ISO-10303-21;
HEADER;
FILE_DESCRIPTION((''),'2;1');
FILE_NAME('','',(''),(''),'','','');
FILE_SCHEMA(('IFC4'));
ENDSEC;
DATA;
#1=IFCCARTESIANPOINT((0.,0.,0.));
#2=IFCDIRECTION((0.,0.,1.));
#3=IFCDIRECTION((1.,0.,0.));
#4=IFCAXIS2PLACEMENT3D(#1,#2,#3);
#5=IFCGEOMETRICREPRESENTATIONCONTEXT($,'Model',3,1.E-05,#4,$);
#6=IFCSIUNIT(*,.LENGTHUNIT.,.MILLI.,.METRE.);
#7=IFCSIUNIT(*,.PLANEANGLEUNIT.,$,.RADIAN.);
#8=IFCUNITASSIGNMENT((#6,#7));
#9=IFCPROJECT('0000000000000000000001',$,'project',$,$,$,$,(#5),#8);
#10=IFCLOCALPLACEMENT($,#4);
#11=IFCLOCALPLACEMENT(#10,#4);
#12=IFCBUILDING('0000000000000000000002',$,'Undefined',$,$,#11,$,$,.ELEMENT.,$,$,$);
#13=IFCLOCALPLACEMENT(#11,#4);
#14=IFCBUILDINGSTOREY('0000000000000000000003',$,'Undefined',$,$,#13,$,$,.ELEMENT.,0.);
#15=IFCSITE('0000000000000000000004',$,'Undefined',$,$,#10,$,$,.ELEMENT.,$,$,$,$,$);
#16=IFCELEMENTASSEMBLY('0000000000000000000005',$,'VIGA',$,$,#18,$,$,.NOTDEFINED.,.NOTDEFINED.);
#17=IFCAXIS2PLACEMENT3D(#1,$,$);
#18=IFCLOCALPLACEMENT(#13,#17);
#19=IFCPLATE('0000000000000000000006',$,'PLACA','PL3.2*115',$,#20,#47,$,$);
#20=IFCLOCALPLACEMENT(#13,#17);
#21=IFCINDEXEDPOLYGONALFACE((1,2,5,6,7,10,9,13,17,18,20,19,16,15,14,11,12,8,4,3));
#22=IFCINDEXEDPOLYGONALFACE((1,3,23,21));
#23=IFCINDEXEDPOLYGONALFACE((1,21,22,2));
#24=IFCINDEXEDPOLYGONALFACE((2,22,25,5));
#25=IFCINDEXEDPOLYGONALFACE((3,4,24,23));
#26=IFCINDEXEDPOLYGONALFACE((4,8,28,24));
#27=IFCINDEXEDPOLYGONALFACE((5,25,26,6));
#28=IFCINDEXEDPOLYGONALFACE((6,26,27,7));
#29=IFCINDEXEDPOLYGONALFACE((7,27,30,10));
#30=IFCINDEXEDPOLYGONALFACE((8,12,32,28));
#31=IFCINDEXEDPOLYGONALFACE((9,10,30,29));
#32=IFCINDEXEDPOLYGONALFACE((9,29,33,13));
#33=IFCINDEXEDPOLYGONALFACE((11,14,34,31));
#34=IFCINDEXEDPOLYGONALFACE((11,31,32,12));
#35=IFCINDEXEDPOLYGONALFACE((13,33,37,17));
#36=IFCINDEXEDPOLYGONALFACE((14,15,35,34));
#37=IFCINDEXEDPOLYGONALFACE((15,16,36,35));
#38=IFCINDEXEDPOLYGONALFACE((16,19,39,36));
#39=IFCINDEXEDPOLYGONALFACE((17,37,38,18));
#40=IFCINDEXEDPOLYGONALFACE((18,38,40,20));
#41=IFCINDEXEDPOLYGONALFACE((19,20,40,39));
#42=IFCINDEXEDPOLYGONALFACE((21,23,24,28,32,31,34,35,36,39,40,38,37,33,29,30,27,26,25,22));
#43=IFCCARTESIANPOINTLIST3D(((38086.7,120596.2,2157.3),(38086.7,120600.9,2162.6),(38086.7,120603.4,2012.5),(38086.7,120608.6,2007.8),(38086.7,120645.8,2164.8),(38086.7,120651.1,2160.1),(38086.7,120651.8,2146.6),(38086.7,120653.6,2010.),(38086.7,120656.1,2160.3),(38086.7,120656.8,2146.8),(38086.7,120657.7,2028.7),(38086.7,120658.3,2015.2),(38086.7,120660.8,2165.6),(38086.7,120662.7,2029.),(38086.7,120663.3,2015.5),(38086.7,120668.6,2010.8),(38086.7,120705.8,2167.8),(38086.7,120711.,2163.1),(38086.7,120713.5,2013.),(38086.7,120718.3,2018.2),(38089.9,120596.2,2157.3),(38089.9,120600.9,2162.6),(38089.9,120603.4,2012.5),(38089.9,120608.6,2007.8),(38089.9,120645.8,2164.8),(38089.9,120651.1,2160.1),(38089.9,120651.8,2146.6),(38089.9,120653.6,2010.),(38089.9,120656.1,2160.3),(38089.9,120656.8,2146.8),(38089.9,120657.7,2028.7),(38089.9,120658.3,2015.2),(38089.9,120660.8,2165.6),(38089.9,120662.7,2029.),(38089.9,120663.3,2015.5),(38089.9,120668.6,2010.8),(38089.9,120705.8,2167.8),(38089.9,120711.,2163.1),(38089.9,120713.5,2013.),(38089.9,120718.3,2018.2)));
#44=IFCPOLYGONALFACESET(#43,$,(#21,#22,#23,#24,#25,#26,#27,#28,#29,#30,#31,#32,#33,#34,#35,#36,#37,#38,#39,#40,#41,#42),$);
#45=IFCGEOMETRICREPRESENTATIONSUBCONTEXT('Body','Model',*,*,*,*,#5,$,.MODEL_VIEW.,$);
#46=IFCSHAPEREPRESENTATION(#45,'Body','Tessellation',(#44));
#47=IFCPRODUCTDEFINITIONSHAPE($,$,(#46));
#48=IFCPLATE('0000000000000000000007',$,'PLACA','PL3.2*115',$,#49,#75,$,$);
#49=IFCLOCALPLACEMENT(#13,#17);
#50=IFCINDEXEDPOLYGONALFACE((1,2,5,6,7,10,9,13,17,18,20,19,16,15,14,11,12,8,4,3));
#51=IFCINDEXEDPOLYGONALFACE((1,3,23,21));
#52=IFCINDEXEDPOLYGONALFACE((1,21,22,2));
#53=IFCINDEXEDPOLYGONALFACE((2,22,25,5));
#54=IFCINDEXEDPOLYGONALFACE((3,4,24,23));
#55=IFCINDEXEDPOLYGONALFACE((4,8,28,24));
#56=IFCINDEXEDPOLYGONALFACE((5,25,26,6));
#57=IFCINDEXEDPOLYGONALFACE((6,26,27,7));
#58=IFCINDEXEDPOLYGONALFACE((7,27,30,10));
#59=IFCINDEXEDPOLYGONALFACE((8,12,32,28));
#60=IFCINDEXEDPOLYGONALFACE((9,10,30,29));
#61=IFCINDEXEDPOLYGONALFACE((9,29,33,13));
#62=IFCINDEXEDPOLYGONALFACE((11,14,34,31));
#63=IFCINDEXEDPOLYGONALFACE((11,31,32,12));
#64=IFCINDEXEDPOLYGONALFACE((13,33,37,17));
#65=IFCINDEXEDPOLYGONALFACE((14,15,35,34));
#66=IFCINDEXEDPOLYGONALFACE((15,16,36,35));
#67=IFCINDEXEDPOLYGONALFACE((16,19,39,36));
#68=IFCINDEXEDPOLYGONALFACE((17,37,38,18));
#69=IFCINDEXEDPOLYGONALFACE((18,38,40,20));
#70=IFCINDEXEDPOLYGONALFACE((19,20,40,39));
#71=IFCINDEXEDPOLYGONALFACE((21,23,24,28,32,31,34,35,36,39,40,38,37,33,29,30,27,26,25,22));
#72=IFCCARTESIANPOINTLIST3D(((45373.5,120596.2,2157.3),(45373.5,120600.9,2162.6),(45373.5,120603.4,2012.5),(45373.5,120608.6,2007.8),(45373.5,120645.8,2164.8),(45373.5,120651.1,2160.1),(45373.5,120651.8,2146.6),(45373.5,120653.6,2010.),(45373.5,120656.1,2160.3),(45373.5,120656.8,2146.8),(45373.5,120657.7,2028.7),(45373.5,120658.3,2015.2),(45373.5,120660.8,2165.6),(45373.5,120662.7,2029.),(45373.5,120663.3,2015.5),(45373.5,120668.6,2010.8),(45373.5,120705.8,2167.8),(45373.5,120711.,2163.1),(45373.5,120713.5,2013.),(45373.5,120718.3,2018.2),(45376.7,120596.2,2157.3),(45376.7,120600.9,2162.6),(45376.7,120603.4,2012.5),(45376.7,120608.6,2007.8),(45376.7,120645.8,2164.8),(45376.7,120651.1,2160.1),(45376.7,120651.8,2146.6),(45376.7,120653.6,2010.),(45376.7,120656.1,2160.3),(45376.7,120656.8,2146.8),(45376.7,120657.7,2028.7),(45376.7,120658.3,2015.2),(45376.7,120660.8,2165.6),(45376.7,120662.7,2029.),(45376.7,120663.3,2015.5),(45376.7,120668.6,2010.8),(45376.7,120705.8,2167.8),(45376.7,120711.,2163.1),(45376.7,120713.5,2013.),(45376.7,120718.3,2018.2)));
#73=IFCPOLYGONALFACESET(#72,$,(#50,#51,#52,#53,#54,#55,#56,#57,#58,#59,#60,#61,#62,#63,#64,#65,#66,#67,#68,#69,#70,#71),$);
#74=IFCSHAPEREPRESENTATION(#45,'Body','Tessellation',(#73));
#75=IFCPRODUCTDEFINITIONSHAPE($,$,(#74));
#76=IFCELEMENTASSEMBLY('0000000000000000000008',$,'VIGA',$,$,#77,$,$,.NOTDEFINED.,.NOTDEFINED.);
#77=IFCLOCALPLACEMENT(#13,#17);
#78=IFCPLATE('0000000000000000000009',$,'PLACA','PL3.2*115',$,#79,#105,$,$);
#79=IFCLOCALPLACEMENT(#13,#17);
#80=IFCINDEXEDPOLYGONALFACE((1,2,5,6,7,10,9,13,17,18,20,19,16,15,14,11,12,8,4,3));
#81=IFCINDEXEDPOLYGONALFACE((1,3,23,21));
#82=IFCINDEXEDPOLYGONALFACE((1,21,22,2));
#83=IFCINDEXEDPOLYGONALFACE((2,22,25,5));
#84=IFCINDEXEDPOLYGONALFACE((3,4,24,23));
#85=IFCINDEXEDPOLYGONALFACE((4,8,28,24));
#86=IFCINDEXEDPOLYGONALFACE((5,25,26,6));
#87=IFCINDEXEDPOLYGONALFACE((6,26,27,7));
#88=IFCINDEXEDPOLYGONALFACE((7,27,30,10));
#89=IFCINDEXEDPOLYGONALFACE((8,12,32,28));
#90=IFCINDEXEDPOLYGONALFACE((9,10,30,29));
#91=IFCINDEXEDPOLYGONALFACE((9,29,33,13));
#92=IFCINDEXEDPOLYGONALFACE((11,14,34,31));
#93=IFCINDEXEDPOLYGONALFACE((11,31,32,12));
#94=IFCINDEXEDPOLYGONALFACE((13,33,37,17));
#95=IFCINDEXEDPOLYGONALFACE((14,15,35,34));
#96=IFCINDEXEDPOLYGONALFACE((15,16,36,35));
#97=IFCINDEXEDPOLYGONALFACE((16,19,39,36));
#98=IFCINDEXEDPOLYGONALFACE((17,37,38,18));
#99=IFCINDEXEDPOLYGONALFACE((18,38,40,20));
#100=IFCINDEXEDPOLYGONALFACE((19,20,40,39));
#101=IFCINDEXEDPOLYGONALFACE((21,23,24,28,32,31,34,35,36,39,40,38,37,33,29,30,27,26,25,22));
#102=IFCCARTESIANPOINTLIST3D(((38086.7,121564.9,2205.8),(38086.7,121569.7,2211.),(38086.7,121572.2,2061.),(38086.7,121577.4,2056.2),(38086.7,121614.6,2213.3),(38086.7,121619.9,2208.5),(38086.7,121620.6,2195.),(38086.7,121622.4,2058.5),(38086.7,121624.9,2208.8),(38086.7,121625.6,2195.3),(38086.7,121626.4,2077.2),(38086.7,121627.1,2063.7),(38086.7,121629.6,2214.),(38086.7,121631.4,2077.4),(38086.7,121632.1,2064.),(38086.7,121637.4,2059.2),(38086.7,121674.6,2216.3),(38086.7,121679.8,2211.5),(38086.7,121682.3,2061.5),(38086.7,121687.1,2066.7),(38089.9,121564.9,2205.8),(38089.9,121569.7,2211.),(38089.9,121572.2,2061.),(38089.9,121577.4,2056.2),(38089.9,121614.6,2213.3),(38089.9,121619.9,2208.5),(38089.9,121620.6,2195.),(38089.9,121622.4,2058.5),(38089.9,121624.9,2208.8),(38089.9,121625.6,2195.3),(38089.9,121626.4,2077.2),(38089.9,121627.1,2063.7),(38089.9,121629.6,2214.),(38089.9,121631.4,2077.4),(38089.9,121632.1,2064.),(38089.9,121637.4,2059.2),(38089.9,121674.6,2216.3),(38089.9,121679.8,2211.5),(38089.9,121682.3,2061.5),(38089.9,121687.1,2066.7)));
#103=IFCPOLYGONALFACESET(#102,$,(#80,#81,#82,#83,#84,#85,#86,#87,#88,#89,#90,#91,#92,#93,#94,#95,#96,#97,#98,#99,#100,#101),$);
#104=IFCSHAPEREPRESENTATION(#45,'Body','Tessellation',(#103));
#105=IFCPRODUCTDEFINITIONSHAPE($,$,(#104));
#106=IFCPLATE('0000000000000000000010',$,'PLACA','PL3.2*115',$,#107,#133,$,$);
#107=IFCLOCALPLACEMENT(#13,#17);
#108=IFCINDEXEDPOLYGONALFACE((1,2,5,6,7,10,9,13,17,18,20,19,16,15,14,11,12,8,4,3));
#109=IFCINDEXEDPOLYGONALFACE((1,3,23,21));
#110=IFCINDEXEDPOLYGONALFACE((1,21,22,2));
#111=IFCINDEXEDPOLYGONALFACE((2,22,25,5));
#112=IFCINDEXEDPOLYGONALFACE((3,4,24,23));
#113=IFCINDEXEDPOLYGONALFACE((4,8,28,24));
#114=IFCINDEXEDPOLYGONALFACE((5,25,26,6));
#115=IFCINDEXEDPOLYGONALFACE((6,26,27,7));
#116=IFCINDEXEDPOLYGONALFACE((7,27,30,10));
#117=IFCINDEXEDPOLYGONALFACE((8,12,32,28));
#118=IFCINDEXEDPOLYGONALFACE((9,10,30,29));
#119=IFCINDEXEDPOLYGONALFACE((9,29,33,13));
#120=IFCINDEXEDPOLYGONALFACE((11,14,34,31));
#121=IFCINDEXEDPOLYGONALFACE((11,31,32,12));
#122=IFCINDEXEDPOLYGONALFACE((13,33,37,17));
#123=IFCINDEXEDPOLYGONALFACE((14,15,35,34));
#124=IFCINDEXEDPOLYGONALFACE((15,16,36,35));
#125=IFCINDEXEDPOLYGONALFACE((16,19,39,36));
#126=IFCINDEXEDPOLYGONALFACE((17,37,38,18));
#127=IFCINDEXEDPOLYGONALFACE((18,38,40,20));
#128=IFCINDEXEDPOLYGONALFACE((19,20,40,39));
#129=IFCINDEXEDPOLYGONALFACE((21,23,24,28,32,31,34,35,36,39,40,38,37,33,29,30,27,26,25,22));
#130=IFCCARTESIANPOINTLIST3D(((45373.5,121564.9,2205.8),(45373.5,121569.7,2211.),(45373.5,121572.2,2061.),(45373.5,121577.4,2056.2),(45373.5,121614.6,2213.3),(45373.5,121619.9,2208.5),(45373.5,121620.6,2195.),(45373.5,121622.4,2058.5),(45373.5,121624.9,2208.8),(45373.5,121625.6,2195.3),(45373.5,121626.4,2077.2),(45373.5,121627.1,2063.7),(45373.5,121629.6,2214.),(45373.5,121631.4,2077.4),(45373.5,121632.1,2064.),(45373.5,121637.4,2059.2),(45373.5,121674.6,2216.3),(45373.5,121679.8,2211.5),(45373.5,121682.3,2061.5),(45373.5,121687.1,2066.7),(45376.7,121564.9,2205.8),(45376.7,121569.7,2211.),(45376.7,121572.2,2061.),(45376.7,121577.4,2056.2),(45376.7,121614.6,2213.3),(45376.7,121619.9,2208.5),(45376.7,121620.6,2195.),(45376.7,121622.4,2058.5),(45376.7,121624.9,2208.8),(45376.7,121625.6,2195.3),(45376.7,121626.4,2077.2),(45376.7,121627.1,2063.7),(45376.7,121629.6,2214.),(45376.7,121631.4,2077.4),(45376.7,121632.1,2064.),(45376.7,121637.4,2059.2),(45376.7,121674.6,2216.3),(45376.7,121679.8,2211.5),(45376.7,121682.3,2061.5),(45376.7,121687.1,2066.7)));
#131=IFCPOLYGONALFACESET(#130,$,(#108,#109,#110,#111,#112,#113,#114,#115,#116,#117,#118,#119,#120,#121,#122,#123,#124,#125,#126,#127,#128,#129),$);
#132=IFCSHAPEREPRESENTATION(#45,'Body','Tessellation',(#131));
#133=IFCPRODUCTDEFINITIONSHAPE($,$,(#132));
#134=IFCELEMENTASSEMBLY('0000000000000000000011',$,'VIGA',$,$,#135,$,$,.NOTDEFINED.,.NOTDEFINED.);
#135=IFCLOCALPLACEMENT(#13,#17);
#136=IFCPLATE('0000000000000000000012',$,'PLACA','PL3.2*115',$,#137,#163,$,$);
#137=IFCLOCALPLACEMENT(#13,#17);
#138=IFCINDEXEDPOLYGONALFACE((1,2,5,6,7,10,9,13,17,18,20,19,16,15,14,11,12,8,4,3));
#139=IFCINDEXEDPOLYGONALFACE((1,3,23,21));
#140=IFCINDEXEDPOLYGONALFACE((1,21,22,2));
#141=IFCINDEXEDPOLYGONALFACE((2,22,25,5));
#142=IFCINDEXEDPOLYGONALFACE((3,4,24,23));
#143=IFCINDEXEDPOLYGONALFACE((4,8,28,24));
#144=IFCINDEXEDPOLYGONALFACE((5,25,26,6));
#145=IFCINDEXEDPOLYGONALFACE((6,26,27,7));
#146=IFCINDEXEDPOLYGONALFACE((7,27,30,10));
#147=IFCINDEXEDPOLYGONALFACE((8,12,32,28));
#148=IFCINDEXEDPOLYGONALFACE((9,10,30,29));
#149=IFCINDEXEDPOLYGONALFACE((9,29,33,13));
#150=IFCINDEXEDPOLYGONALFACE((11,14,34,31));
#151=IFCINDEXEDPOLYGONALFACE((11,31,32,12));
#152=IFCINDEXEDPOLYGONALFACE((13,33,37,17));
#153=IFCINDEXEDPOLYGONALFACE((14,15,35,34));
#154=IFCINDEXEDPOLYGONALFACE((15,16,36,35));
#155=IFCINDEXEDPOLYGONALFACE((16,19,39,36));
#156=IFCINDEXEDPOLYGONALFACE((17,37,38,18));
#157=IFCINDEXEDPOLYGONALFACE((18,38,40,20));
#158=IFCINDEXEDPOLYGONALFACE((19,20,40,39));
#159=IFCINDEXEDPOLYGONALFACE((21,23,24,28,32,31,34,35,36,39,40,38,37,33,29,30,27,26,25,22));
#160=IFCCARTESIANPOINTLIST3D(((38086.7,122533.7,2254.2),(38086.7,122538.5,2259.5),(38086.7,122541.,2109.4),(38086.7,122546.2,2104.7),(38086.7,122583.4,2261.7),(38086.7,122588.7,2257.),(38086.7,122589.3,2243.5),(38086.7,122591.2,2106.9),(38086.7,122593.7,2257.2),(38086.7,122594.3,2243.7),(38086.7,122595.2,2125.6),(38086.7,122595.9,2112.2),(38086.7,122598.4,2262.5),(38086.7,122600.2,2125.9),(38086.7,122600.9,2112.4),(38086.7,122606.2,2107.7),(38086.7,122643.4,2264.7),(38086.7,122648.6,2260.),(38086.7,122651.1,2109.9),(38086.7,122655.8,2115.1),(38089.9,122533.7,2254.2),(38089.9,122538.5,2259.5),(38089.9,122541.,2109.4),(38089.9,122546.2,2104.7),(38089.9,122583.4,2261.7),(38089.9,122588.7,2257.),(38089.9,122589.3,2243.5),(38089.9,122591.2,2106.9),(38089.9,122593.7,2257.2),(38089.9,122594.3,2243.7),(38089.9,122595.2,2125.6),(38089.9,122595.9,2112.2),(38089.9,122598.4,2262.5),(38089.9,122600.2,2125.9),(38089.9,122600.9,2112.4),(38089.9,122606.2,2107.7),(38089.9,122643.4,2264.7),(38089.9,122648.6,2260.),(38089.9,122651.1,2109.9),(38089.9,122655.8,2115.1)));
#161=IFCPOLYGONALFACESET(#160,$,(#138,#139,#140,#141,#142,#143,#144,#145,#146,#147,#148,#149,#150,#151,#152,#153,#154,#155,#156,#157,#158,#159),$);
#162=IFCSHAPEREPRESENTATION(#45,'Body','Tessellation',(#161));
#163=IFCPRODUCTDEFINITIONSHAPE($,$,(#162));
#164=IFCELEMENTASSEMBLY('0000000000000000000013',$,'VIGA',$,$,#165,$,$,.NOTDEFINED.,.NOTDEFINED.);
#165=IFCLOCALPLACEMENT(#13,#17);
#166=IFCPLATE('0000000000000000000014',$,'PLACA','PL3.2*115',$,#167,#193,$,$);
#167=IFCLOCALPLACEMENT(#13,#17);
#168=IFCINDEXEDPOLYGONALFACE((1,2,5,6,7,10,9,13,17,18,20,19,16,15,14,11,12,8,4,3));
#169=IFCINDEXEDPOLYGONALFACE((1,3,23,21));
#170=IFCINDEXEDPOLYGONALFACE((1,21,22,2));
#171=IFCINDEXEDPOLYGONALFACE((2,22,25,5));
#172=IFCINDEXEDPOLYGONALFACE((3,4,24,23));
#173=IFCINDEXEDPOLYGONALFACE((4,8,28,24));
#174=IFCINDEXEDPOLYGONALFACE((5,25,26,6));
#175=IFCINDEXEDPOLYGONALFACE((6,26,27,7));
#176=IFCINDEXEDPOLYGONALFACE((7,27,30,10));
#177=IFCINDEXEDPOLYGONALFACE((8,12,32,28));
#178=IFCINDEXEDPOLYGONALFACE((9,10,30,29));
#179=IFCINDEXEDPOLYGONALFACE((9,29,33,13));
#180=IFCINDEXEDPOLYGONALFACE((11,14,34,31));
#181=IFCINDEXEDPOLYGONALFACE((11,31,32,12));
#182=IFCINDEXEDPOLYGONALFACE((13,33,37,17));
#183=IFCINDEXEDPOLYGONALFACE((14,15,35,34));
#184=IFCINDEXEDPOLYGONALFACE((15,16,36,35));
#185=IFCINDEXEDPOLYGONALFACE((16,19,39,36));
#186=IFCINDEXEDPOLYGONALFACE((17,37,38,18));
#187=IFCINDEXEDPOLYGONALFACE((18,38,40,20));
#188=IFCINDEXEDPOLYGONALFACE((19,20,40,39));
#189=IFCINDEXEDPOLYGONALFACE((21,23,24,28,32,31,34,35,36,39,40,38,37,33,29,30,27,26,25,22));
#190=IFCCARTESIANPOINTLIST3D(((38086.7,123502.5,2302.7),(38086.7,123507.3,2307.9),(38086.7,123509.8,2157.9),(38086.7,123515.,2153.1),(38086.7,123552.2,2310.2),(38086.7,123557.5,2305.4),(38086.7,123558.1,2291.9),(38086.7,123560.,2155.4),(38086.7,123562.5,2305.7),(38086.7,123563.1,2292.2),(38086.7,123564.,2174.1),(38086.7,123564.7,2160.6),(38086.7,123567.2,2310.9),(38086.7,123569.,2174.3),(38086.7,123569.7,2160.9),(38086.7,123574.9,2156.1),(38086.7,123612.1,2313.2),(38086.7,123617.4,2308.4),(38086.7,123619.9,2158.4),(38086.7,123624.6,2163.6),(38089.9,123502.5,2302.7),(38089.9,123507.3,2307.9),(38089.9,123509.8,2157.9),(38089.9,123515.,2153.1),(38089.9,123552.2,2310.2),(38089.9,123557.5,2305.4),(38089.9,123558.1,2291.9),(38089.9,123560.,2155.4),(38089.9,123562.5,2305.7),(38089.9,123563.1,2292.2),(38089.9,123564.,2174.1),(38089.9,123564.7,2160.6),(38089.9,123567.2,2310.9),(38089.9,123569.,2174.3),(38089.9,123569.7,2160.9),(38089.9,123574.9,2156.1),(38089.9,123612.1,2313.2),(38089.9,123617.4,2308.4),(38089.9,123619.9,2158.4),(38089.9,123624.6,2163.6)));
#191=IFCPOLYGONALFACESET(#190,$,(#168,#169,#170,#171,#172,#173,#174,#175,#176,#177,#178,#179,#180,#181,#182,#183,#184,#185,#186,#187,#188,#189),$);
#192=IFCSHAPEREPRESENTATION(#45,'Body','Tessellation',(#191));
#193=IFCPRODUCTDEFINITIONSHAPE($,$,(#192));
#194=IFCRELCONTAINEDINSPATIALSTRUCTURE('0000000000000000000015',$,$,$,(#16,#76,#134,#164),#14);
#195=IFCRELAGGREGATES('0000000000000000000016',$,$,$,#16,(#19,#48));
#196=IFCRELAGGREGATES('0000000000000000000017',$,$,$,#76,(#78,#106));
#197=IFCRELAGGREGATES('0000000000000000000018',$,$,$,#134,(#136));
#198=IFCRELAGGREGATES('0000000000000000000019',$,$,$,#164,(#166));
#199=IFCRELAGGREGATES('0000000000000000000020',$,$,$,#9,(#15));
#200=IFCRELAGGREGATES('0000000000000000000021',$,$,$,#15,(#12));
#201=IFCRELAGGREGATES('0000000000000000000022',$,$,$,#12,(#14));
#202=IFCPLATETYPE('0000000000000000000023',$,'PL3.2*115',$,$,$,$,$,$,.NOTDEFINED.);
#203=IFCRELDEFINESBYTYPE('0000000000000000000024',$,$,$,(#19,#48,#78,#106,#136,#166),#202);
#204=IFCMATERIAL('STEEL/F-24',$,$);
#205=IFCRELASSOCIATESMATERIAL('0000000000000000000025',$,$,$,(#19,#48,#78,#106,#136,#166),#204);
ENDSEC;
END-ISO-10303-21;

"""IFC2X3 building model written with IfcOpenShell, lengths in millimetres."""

from ifc_helpers import new_model, si_unit, frame, origin_with_axes, place, context, subcontext, project, spatial, polyline, outline, extrude, material, type_object, element, aggregate, save


model = new_model("IFC2X3")

# Units and contexts
model_context = context("Model", 3, precision=1e-05, world=origin_with_axes())
body_context = subcontext(model_context, "Body", "Model", "MODEL_VIEW")
ifc_project = project(units=[si_unit("LENGTHUNIT", "METRE", prefix="MILLI"), si_unit("PLANEANGLEUNIT", "RADIAN")], contexts=[model_context])

# Site, building, storey
site_placement = place(None, origin_with_axes())
site = spatial("IfcSite", under=ifc_project, at=site_placement, Name="Undefined", CompositionType="ELEMENT")
building_placement = place(site_placement, origin_with_axes())
building = spatial("IfcBuilding", under=site, at=building_placement, Name="Undefined", CompositionType="ELEMENT")
storey_placement = place(building_placement, origin_with_axes())
storey = spatial("IfcBuildingStorey", under=building, at=storey_placement, Name="Undefined", CompositionType="ELEMENT", Elevation=0.0)

# Shared definitions
ifc_material_1 = material(Name="STEEL/F-24")

# Element assemblies, plates
assembly_1_placement = place(storey_placement, origin_with_axes())
assembly_1 = element("IfcElementAssembly", 1, at=assembly_1_placement, inside=storey, Name="VIGA", AssemblyPlace="NOTDEFINED", PredefinedType="NOTDEFINED")
plate_type_1 = type_object("IfcPlateType", Name="PL3.2*115", PredefinedType="NOTDEFINED")
plate_1_placement = place(assembly_1_placement, frame((38088.3, 120595.9, 2162.3), z_axis=(-1.0, 0.0, 0.0), x_axis=(0.0, 0.998752, 0.04995)))
plate_1 = element("IfcPlate", 2, at=plate_1_placement, type_object=plate_type_1, material=ifc_material_1, Name="PLACA", Description="PL3.2*115", context=body_context, shape_type="SweptSolid", body=[
    extrude(outline(polyline([(0.0, 5.0), (5.0, 0.0), (50.0, 0.0), (55.0, 5.0), (55.0, 18.5), (60.0, 18.5), (60.0, 5.0), (65.0, 0.0), (110.0, 0.0), (115.0, 5.0), (115.0, 150.0), (110.0, 155.0), (65.0, 155.0), (60.0, 150.0), (60.0, 136.5), (55.0, 136.5), (55.0, 150.0), (50.0, 155.0), (5.0, 155.0), (0.0, 150.0), (0.0, 5.0)])), frame((0.0, 0.0, -1.6), z_axis=(0.0, 0.0, 1.0), x_axis=(1.0, 0.0, 0.0)), (0.0, 0.0, 1.0), 3.2),
])
plate_2_placement = place(assembly_1_placement, frame((45375.1, 120595.9, 2162.3), z_axis=(-1.0, 0.0, 0.0), x_axis=(0.0, 0.998752, 0.04995)))
plate_2 = element("IfcPlate", 3, at=plate_2_placement, type_object=plate_type_1, material=ifc_material_1, Name="PLACA", Description="PL3.2*115", context=body_context, shape_type="SweptSolid", body=[
    extrude(outline(polyline([(0.0, 5.0), (5.0, 0.0), (50.0, 0.0), (55.0, 5.0), (55.0, 18.5), (60.0, 18.5), (60.0, 5.0), (65.0, 0.0), (110.0, 0.0), (115.0, 5.0), (115.0, 150.0), (110.0, 155.0), (65.0, 155.0), (60.0, 150.0), (60.0, 136.5), (55.0, 136.5), (55.0, 150.0), (50.0, 155.0), (5.0, 155.0), (0.0, 150.0), (0.0, 5.0)])), frame((0.0, 0.0, -1.6), z_axis=(0.0, 0.0, 1.0), x_axis=(1.0, 0.0, 0.0)), (0.0, 0.0, 1.0), 3.2),
])
assembly_2_placement = place(storey_placement, origin_with_axes())
assembly_2 = element("IfcElementAssembly", 4, at=assembly_2_placement, inside=storey, Name="VIGA", AssemblyPlace="NOTDEFINED", PredefinedType="NOTDEFINED")
plate_3_placement = place(assembly_2_placement, frame((38088.3, 121564.7, 2210.8), z_axis=(-1.0, 0.0, 0.0), x_axis=(0.0, 0.998752, 0.04995)))
plate_3 = element("IfcPlate", 5, at=plate_3_placement, type_object=plate_type_1, material=ifc_material_1, Name="PLACA", Description="PL3.2*115", context=body_context, shape_type="SweptSolid", body=[
    extrude(outline(polyline([(0.0, 5.0), (5.0, 0.0), (50.0, 0.0), (55.0, 5.0), (55.0, 18.5), (60.0, 18.5), (60.0, 5.0), (65.0, 0.0), (110.0, 0.0), (115.0, 5.0), (115.0, 150.0), (110.0, 155.0), (65.0, 155.0), (60.0, 150.0), (60.0, 136.5), (55.0, 136.5), (55.0, 150.0), (50.0, 155.0), (5.0, 155.0), (0.0, 150.0), (0.0, 5.0)])), frame((0.0, 0.0, -1.6), z_axis=(0.0, 0.0, 1.0), x_axis=(1.0, 0.0, 0.0)), (0.0, 0.0, 1.0), 3.2),
])
plate_4_placement = place(assembly_2_placement, frame((45375.1, 121564.7, 2210.8), z_axis=(-1.0, 0.0, 0.0), x_axis=(0.0, 0.998752, 0.04995)))
plate_4 = element("IfcPlate", 6, at=plate_4_placement, type_object=plate_type_1, material=ifc_material_1, Name="PLACA", Description="PL3.2*115", context=body_context, shape_type="SweptSolid", body=[
    extrude(outline(polyline([(0.0, 5.0), (5.0, 0.0), (50.0, 0.0), (55.0, 5.0), (55.0, 18.5), (60.0, 18.5), (60.0, 5.0), (65.0, 0.0), (110.0, 0.0), (115.0, 5.0), (115.0, 150.0), (110.0, 155.0), (65.0, 155.0), (60.0, 150.0), (60.0, 136.5), (55.0, 136.5), (55.0, 150.0), (50.0, 155.0), (5.0, 155.0), (0.0, 150.0), (0.0, 5.0)])), frame((0.0, 0.0, -1.6), z_axis=(0.0, 0.0, 1.0), x_axis=(1.0, 0.0, 0.0)), (0.0, 0.0, 1.0), 3.2),
])

# Element assemblies, plates
assembly_3_placement = place(storey_placement, origin_with_axes())
assembly_3 = element("IfcElementAssembly", 7, at=assembly_3_placement, inside=storey, Name="VIGA", AssemblyPlace="NOTDEFINED", PredefinedType="NOTDEFINED")
plate_5_placement = place(assembly_3_placement, frame((38088.3, 122533.5, 2259.2), z_axis=(-1.0, 0.0, 0.0), x_axis=(0.0, 0.998752, 0.04995)))
plate_5 = element("IfcPlate", 8, at=plate_5_placement, type_object=plate_type_1, material=ifc_material_1, Name="PLACA", Description="PL3.2*115", context=body_context, shape_type="SweptSolid", body=[
    extrude(outline(polyline([(0.0, 5.0), (5.0, 0.0), (50.0, 0.0), (55.0, 5.0), (55.0, 18.5), (60.0, 18.5), (60.0, 5.0), (65.0, 0.0), (110.0, 0.0), (115.0, 5.0), (115.0, 150.0), (110.0, 155.0), (65.0, 155.0), (60.0, 150.0), (60.0, 136.5), (55.0, 136.5), (55.0, 150.0), (50.0, 155.0), (5.0, 155.0), (0.0, 150.0), (0.0, 5.0)])), frame((0.0, 0.0, -1.6), z_axis=(0.0, 0.0, 1.0), x_axis=(1.0, 0.0, 0.0)), (0.0, 0.0, 1.0), 3.2),
])
assembly_4_placement = place(storey_placement, origin_with_axes())
assembly_4 = element("IfcElementAssembly", 9, at=assembly_4_placement, inside=storey, Name="VIGA", AssemblyPlace="NOTDEFINED", PredefinedType="NOTDEFINED")
plate_6_placement = place(assembly_4_placement, frame((38088.3, 123502.3, 2307.7), z_axis=(-1.0, 0.0, 0.0), x_axis=(0.0, 0.998752, 0.04995)))
plate_6 = element("IfcPlate", 10, at=plate_6_placement, type_object=plate_type_1, material=ifc_material_1, Name="PLACA", Description="PL3.2*115", context=body_context, shape_type="SweptSolid", body=[
    extrude(outline(polyline([(0.0, 5.0), (5.0, 0.0), (50.0, 0.0), (55.0, 5.0), (55.0, 18.5), (60.0, 18.5), (60.0, 5.0), (65.0, 0.0), (110.0, 0.0), (115.0, 5.0), (115.0, 150.0), (110.0, 155.0), (65.0, 155.0), (60.0, 150.0), (60.0, 136.5), (55.0, 136.5), (55.0, 150.0), (50.0, 155.0), (5.0, 155.0), (0.0, 150.0), (0.0, 5.0)])), frame((0.0, 0.0, -1.6), z_axis=(0.0, 0.0, 1.0), x_axis=(1.0, 0.0, 0.0)), (0.0, 0.0, 1.0), 3.2),
])

aggregate(assembly_1, [plate_1, plate_2])
aggregate(assembly_2, [plate_3, plate_4])
aggregate(assembly_3, [plate_5])
aggregate(assembly_4, [plate_6])

save(model, "model.ifc")
